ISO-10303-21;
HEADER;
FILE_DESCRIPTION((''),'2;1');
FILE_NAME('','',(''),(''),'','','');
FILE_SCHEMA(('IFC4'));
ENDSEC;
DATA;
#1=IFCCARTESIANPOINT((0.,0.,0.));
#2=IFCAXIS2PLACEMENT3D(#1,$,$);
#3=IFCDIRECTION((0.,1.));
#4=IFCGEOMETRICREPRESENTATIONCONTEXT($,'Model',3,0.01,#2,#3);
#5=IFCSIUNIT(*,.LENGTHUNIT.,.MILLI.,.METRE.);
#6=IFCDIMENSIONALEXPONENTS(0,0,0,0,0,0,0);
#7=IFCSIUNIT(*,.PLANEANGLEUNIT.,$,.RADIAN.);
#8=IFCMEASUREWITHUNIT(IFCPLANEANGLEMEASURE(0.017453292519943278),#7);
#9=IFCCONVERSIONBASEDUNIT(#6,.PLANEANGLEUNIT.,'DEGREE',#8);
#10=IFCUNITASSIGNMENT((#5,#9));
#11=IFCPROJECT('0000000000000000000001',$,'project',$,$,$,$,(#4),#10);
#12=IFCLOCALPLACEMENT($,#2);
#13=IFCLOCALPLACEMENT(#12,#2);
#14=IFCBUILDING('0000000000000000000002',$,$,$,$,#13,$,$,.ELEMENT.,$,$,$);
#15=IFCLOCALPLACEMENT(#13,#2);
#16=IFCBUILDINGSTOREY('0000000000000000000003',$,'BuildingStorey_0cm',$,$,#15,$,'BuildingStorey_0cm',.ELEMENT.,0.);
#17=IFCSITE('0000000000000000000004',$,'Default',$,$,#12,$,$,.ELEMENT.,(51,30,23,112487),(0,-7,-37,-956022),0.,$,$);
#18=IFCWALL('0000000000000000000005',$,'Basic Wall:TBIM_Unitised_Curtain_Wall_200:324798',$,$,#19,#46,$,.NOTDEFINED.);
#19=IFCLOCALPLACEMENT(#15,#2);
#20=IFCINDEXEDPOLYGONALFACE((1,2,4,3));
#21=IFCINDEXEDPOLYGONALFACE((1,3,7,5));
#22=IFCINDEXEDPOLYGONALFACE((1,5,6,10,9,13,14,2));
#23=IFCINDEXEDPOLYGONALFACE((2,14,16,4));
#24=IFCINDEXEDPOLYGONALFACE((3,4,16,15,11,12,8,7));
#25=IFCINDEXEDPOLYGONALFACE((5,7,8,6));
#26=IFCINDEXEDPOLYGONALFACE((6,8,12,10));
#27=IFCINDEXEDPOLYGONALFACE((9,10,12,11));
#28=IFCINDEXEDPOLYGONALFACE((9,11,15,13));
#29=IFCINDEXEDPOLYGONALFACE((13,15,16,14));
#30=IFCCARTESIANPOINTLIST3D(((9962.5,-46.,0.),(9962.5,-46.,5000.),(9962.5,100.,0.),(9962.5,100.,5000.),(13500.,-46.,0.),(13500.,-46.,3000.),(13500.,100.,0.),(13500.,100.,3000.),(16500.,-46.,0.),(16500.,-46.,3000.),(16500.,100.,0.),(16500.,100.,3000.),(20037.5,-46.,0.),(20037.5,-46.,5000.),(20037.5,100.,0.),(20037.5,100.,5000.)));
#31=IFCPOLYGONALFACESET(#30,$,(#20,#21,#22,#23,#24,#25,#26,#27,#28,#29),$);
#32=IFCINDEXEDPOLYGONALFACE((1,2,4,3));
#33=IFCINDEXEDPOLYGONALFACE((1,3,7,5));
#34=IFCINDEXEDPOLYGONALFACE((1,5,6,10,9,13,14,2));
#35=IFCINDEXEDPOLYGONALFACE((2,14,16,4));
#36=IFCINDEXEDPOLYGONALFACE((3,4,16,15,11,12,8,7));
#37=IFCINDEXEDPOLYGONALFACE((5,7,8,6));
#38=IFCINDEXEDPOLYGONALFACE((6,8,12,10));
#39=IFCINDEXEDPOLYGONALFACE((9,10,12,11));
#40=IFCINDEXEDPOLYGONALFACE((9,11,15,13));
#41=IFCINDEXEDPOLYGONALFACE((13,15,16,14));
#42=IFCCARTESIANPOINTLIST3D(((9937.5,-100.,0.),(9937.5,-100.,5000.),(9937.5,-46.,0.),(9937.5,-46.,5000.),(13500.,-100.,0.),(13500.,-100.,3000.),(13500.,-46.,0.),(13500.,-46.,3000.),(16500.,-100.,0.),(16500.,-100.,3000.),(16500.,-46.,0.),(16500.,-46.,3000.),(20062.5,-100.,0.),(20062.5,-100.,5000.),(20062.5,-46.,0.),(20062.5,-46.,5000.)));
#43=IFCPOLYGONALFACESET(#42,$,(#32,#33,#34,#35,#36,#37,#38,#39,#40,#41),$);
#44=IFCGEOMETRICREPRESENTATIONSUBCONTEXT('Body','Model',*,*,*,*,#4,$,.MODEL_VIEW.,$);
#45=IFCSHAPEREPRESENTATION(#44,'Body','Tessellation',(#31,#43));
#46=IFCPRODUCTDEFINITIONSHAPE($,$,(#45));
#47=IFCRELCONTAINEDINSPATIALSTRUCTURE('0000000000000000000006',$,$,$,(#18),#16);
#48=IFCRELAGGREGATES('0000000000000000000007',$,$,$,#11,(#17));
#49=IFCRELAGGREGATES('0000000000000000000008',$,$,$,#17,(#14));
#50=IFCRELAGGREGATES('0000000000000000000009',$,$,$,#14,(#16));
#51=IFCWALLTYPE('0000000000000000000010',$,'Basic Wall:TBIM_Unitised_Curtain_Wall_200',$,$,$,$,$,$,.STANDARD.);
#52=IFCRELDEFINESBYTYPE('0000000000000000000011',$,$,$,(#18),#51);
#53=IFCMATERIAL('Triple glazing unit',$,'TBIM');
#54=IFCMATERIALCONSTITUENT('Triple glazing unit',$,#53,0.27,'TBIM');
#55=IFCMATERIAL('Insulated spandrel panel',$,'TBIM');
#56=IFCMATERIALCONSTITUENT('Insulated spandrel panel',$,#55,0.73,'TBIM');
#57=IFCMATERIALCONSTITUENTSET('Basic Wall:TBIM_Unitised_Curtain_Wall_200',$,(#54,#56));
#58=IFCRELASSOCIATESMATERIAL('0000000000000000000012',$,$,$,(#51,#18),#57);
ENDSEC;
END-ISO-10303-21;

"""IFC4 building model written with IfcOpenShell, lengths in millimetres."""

from ifc_helpers import new_model, entity, si_unit, converted_unit, direction, frame, origin, place, context, subcontext, project, spatial, indexed_curve, outline, extrude, material, constituent, constituent_set, type_object, element, save


model = new_model("IFC4")

# Units and contexts
model_context = context("Model", 3, precision=0.01, world=origin(), true_north=direction((0.0, 1.0)))
body_context = subcontext(model_context, "Body", "Model", "MODEL_VIEW")
ifc_project = project(units=[si_unit("LENGTHUNIT", "METRE", prefix="MILLI"), converted_unit("PLANEANGLEUNIT", "DEGREE", entity("IfcPlaneAngleMeasure", 0.017453292519943278), si_unit("PLANEANGLEUNIT", "RADIAN"), dimensions=[0, 0, 0, 0, 0, 0, 0])], contexts=[model_context])

# Site, building, storey
site_placement = place(None, origin())
site = spatial("IfcSite", under=ifc_project, at=site_placement, Name="Default", CompositionType="ELEMENT", RefLatitude=(51, 30, 23, 112487), RefLongitude=(0, -7, -37, -956022), RefElevation=0.0)
building_placement = place(site_placement, origin())
building = spatial("IfcBuilding", under=site, at=building_placement, CompositionType="ELEMENT")
storey_placement = place(building_placement, origin())
storey = spatial("IfcBuildingStorey", under=building, at=storey_placement, Name="BuildingStorey_0cm", LongName="BuildingStorey_0cm", CompositionType="ELEMENT", Elevation=0.0)

# Wall, opening
ifc_material_1 = material(Name="Triple glazing unit", Category="TBIM")
ifc_constituent_1 = constituent(ifc_material_1, Name="Triple glazing unit", Category="TBIM", fraction=0.27)
ifc_material_2 = material(Name="Insulated spandrel panel", Category="TBIM")
ifc_constituent_2 = constituent(ifc_material_2, Name="Insulated spandrel panel", Category="TBIM", fraction=0.73)
ifc_constituent_set_1 = constituent_set(constituents=[ifc_constituent_1, ifc_constituent_2], Name="Basic Wall:TBIM_Unitised_Curtain_Wall_200")
wall_type_1 = type_object("IfcWallType", Name="Basic Wall:TBIM_Unitised_Curtain_Wall_200", PredefinedType="STANDARD", material=ifc_constituent_set_1)
wall_1_placement = place(storey_placement, frame((9937.5, 0.0, 0.0)))
wall_1 = element("IfcWall", 1, at=wall_1_placement, inside=storey, type_object=wall_type_1, material=ifc_constituent_set_1, Name="Basic Wall:TBIM_Unitised_Curtain_Wall_200:324798", PredefinedType="NOTDEFINED", context=body_context, shape_type="SweptSolid", body=[
    extrude(outline(indexed_curve([(-2000.0, -5037.5), (3000.0, -5037.5), (3000.0, 5037.5), (-2000.0, 5037.5), (-2000.0, 1500.0), (1000.0, 1500.0), (1000.0, -1500.0), (-2000.0, -1500.0), (-2000.0, -5037.5)], self_intersect=False)), frame((5062.5, -46.0, 2000.0), z_axis=(0.0, 1.0, 0.0), x_axis=(0.0, 0.0, 1.0)), (0.0, 0.0, 1.0), 146.0),
    extrude(outline(indexed_curve([(-1500.0, -1000.0), (-1500.0, 2000.0), (-5062.5, 2000.0), (-5062.5, -3000.0), (5062.5, -3000.0), (5062.5, 2000.0), (1500.0, 2000.0), (1500.0, -1000.0), (-1500.0, -1000.0)], self_intersect=False)), frame((5062.5, -100.0, 2000.0), z_axis=(0.0, -1.0, 0.0), x_axis=(-1.0, 0.0, 0.0)), (0.0, 0.0, -1.0), 54.0),
])
opening_1_placement = place(wall_1_placement, frame((6562.5, 100.0, 0.0)))
element("IfcOpeningElement", 2, at=opening_1_placement, cuts=wall_1, PredefinedType="OPENING", context=body_context, shape_type="SweptSolid", body=[
    extrude(outline(indexed_curve([(3000.0, 3000.0), (0.0, 3000.0), (0.0, 0.0), (3000.0, 0.0), (3000.0, 3000.0)], self_intersect=False)), frame((0.0, 0.0, 0.0), z_axis=(0.0, -1.0, 0.0), x_axis=(0.0, 0.0, 1.0)), (0.0, 0.0, 1.0), 200.0),
])

save(model, "model.ifc")
